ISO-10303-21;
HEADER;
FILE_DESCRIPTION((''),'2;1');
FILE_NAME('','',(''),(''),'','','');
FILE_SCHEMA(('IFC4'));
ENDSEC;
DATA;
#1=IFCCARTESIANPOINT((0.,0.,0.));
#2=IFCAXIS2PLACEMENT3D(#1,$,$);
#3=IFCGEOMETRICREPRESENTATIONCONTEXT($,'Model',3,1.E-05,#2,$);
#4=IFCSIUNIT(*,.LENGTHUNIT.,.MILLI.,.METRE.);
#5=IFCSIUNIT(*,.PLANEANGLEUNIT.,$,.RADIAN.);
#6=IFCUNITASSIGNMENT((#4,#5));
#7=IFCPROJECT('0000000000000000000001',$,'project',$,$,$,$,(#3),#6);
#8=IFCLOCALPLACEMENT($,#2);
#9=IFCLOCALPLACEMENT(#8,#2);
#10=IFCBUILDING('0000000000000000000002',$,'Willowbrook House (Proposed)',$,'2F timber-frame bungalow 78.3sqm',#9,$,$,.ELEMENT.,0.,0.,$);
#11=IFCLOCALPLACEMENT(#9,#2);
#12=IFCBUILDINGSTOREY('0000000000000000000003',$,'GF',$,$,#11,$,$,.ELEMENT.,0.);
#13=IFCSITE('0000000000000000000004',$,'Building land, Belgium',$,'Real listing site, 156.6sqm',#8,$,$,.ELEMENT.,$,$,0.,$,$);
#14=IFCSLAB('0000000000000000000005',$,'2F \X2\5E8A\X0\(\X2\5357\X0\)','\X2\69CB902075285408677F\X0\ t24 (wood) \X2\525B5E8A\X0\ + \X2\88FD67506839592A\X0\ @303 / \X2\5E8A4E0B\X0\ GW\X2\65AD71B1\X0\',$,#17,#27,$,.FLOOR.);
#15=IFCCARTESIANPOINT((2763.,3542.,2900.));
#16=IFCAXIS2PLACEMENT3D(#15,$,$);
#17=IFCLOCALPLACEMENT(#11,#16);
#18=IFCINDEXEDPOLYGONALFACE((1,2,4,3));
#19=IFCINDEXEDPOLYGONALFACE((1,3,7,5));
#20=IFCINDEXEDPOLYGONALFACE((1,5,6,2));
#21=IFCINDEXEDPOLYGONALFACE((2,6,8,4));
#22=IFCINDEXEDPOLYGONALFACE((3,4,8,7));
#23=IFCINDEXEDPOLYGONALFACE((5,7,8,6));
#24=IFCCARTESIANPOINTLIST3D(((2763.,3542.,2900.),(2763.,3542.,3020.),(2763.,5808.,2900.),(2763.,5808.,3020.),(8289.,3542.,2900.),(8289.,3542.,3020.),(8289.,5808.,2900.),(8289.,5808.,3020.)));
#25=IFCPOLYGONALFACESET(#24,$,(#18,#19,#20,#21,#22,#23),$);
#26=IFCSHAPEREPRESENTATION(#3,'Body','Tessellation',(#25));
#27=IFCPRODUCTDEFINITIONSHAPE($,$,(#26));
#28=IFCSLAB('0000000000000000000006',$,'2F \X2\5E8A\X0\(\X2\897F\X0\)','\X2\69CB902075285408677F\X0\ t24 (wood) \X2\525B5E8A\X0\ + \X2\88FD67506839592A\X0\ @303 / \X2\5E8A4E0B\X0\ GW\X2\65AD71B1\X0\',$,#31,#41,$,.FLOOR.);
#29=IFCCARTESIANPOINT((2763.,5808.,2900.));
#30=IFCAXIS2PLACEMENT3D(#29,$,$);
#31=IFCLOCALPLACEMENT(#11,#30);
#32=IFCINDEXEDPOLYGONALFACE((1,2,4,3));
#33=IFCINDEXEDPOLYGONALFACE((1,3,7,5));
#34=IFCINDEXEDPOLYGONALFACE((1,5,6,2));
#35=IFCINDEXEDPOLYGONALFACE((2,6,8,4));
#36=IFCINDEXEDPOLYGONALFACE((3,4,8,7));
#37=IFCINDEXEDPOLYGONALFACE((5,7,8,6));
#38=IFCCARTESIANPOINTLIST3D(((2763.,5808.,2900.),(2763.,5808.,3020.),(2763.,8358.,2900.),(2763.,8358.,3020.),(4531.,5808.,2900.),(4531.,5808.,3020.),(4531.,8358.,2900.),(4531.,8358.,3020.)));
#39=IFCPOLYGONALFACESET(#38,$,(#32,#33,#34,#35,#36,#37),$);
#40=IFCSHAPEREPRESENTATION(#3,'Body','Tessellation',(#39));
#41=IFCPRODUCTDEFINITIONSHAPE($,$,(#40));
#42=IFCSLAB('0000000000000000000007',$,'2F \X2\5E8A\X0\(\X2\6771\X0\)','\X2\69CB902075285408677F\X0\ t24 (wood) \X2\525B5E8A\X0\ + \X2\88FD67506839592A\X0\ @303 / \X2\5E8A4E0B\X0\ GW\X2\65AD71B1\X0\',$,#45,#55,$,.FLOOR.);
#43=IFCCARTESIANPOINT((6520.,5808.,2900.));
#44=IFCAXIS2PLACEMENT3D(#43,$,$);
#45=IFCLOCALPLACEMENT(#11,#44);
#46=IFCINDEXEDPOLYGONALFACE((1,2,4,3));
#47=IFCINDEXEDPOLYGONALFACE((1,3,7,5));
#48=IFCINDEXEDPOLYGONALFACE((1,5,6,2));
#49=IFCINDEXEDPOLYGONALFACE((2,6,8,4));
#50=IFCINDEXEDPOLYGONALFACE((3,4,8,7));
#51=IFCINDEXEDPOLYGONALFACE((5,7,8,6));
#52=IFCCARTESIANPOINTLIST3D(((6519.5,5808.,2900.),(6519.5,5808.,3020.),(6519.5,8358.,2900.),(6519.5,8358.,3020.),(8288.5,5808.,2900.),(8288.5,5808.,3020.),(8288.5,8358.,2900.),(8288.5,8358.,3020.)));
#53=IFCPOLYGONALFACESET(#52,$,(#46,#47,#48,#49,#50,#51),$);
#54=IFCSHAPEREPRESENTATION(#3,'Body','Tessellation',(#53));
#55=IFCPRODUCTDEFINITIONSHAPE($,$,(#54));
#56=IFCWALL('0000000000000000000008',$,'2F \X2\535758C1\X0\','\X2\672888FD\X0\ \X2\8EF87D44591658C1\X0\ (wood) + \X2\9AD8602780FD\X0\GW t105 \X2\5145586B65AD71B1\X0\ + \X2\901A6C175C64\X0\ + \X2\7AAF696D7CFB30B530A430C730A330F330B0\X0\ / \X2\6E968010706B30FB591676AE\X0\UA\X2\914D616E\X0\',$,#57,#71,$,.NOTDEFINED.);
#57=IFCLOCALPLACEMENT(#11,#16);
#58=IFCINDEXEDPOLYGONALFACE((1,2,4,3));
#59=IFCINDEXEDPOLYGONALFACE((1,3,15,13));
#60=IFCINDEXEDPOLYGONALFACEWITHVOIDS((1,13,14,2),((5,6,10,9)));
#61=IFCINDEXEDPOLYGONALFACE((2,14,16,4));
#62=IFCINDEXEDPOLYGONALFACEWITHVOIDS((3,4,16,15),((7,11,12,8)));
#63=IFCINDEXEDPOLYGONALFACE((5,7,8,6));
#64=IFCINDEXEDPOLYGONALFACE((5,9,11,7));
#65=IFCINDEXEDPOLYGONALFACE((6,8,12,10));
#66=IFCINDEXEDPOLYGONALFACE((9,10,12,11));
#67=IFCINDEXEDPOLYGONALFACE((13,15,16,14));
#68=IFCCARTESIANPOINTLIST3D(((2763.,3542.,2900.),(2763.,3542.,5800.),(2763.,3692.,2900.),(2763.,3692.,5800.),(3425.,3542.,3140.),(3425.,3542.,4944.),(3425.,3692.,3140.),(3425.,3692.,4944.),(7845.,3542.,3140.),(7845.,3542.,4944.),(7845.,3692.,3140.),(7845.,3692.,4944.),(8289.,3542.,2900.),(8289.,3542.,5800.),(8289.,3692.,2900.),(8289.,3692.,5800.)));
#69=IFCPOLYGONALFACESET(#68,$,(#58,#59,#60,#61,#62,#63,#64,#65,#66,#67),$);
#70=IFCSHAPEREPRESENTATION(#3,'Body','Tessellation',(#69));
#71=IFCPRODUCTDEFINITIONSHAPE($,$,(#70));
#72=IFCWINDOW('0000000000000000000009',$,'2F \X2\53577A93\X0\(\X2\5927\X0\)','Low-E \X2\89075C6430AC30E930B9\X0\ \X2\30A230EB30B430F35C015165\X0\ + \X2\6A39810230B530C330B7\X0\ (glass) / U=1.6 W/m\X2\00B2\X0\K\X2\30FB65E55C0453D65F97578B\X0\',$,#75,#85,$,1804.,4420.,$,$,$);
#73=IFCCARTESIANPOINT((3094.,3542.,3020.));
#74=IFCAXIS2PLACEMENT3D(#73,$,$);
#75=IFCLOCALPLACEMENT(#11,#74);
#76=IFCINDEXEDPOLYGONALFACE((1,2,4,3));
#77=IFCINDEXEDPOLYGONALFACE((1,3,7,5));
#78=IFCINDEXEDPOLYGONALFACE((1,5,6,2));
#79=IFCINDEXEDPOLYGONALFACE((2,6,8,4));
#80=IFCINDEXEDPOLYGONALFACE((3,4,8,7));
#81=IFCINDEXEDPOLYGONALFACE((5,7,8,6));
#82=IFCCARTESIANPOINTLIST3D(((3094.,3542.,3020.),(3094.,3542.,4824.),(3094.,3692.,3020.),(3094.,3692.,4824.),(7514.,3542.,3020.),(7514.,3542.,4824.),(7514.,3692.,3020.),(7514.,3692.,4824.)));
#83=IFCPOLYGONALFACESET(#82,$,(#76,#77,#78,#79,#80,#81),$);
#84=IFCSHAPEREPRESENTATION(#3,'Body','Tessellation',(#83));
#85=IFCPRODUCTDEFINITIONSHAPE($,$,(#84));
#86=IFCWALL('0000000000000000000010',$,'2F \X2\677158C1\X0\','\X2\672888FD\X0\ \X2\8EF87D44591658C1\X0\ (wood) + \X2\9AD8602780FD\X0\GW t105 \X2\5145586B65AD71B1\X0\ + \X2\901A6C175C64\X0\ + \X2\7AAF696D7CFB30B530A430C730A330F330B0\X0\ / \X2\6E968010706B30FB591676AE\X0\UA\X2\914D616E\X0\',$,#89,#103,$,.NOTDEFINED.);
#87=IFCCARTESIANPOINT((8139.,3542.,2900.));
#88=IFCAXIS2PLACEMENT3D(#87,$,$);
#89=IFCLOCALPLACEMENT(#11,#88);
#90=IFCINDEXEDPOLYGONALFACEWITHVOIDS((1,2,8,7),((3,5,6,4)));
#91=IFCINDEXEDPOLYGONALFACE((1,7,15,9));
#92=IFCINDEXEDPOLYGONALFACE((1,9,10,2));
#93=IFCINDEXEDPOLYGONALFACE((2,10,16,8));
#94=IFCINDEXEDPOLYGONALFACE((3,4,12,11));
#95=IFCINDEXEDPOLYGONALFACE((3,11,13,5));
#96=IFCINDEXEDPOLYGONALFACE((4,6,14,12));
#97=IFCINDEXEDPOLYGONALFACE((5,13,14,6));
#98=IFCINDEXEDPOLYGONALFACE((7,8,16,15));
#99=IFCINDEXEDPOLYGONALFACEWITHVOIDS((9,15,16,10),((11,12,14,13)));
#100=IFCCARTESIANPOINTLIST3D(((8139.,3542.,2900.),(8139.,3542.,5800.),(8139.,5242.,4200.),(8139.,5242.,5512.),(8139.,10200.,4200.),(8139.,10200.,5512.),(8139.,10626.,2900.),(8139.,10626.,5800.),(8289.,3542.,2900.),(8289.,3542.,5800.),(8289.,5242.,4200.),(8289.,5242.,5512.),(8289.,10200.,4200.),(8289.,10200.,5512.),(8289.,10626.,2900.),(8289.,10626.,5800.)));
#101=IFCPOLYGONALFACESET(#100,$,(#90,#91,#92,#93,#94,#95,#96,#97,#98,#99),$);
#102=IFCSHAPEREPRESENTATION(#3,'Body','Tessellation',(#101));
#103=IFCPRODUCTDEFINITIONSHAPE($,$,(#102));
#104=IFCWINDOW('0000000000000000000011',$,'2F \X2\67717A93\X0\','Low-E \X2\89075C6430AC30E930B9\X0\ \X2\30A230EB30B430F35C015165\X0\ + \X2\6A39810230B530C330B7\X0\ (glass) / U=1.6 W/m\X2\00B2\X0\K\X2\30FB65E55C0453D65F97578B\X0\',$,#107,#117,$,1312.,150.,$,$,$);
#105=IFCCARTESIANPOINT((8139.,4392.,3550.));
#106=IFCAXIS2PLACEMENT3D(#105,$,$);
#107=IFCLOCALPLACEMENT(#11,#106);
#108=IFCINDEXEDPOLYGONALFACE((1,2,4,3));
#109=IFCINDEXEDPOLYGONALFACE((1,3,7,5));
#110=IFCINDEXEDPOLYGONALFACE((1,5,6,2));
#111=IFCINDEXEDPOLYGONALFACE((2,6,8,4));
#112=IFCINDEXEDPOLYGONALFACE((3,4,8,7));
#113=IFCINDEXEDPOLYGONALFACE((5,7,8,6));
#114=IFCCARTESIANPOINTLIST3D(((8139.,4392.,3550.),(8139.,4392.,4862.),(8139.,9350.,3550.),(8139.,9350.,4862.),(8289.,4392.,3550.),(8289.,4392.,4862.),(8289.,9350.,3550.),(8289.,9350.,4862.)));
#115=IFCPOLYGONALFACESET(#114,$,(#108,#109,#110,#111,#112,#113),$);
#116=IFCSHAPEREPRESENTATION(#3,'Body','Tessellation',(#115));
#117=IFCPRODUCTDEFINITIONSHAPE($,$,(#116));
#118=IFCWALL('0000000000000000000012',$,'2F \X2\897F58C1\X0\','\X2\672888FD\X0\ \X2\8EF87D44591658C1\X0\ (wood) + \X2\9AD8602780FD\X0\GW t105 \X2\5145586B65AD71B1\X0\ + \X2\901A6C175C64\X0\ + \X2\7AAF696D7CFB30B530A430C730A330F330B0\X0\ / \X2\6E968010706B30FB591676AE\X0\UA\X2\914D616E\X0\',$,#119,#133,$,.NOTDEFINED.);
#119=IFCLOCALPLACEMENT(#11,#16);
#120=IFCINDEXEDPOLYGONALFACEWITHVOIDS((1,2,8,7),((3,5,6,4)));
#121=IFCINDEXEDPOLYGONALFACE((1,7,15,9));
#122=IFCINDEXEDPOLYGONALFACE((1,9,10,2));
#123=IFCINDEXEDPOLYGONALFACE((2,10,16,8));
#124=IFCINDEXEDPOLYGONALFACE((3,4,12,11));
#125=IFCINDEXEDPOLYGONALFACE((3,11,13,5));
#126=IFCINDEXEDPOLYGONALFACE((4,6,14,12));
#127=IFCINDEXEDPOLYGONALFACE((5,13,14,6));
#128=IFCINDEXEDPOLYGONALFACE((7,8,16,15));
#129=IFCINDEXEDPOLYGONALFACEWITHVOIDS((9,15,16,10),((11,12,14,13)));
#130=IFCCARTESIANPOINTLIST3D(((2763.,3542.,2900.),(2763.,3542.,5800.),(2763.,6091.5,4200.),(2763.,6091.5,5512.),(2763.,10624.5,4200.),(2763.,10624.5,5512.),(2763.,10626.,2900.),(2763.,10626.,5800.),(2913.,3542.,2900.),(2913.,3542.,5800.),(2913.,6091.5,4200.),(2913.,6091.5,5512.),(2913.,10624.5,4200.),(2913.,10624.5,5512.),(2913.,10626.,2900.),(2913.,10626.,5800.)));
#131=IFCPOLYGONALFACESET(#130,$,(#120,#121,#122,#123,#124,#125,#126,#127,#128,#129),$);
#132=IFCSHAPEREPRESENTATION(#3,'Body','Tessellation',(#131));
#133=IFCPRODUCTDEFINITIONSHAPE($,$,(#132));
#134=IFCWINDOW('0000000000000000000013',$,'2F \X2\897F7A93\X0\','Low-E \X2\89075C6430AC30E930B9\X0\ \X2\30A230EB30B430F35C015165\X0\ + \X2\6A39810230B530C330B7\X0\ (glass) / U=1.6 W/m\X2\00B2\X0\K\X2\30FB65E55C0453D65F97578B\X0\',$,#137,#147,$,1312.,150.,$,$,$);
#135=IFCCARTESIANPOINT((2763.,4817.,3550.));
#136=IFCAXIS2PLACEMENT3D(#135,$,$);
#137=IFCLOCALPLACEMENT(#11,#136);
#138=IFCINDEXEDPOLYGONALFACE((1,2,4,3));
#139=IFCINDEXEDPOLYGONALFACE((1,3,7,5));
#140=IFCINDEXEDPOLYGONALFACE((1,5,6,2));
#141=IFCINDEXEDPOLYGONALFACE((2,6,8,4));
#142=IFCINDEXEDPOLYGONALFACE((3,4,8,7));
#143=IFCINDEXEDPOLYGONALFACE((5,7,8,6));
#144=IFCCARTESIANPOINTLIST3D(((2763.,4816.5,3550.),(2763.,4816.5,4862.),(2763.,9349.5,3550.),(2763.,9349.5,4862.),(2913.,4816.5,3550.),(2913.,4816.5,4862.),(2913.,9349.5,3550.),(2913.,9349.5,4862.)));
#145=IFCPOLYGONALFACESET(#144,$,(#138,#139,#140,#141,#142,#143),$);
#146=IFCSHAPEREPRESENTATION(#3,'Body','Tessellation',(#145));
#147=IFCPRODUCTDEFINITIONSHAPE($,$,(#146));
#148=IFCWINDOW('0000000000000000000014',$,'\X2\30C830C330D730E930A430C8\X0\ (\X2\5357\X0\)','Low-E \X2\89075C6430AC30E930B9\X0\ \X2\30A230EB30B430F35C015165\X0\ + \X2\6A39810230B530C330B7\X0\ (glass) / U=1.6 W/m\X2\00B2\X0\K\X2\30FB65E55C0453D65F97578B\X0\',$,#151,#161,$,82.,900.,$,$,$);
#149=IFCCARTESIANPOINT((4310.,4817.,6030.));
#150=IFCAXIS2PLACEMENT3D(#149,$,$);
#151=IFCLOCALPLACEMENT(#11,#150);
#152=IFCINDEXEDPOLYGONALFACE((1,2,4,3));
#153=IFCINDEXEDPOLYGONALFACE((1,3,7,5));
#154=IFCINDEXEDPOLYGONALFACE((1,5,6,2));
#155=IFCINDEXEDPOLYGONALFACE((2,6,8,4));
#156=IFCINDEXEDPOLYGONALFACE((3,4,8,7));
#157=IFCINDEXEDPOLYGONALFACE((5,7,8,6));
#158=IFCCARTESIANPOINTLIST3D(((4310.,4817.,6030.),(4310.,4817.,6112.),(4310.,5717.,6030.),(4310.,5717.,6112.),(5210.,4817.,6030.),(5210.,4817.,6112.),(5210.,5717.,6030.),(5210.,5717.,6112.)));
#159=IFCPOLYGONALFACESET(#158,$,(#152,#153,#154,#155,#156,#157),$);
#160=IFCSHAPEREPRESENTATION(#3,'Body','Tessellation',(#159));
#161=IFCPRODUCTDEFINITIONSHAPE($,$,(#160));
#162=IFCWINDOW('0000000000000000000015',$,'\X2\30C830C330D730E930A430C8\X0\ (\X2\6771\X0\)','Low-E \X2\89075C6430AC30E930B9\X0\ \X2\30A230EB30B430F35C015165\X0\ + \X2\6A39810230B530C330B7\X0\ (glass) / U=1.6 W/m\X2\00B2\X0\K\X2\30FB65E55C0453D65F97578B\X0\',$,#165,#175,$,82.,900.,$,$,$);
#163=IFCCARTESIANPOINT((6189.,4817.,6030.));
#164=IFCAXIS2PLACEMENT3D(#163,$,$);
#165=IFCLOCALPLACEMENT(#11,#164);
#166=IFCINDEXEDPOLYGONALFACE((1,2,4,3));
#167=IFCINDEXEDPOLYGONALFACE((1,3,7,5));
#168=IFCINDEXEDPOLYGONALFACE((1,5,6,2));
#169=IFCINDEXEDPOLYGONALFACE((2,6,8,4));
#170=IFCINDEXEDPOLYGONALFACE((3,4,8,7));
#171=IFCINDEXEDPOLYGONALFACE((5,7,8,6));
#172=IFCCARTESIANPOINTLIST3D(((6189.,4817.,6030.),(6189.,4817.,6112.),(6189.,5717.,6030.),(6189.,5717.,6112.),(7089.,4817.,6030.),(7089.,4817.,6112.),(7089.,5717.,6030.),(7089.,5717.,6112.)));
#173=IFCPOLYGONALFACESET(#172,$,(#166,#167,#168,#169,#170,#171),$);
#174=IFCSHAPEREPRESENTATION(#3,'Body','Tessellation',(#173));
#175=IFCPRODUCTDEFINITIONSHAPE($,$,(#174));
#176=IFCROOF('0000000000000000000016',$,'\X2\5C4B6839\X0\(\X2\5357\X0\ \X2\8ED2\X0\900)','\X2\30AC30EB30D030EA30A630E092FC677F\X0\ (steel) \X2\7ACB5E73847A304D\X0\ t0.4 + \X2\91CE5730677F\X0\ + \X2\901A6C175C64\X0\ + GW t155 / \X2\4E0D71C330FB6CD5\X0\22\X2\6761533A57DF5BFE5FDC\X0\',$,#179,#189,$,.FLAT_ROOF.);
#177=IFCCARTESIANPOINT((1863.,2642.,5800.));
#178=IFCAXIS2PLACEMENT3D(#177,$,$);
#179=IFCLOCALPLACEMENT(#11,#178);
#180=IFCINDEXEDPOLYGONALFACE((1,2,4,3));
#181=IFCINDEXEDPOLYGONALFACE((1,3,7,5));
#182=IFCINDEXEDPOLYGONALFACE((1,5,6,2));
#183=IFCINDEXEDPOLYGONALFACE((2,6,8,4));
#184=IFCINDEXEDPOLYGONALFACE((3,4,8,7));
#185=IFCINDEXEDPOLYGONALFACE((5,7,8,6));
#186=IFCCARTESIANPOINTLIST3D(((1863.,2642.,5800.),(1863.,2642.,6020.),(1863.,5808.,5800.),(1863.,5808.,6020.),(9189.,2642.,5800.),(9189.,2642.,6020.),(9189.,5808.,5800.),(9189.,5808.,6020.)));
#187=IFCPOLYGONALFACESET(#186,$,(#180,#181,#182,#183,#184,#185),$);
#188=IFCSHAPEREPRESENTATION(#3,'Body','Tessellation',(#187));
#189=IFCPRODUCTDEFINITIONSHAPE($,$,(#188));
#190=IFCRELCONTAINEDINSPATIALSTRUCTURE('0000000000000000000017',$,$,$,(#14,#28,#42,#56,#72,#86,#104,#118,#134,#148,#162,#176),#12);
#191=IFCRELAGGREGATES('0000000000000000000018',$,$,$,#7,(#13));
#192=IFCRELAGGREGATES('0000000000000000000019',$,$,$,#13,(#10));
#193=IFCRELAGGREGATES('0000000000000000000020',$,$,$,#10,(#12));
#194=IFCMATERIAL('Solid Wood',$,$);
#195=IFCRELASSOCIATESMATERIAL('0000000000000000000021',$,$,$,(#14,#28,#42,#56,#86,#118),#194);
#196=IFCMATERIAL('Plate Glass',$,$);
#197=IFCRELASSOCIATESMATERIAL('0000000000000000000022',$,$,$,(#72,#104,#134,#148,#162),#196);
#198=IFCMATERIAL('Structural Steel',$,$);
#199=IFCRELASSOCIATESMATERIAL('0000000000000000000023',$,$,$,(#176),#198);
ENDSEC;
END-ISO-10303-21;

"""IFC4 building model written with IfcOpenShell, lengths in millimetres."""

from ifc_helpers import new_model, si_unit, frame, frame_2d, origin, place, context, project, spatial, rectangle, extrude, material, element, fill, save


model = new_model("IFC4")

# Units and contexts
model_context = context("Model", 3, precision=1e-05, world=origin())
ifc_project = project(units=[si_unit("LENGTHUNIT", "METRE", prefix="MILLI"), si_unit("PLANEANGLEUNIT", "RADIAN")], contexts=[model_context])

# Site, building, storey
site_placement = place(None, origin())
site = spatial("IfcSite", under=ifc_project, at=site_placement, Name="Building land, Belgium", ObjectType="Real listing site, 156.6sqm", CompositionType="ELEMENT", RefElevation=0.0)
building_placement = place(site_placement, origin())
building = spatial("IfcBuilding", under=site, at=building_placement, Name="Willowbrook House (Proposed)", ObjectType="2F timber-frame bungalow 78.3sqm", CompositionType="ELEMENT", ElevationOfRefHeight=0.0, ElevationOfTerrain=0.0)
storey_placement = place(building_placement, origin())
storey = spatial("IfcBuildingStorey", under=building, at=storey_placement, Name="GF", CompositionType="ELEMENT", Elevation=0.0)

# Slabs
ifc_material_1 = material(Name="Solid Wood")
slab_1_placement = place(storey_placement, frame((2763.0, 3542.0, 2900.0)))
element("IfcSlab", 1, at=slab_1_placement, inside=storey, material=ifc_material_1, Name="2F 床(南)", Description="構造用合板 t24 (wood) 剛床 + 製材根太 @303 / 床下 GW断熱", PredefinedType="FLOOR", context=model_context, shape_type="SweptSolid", body=[
    extrude(rectangle(XDim=5526.0, YDim=2266.0, at=frame_2d((2763.0, 1133.0))), frame((2763.0, 3542.0, 2900.0)), (0.0, 0.0, 1.0), 120.0),
])
slab_2_placement = place(storey_placement, frame((2763.0, 5808.0, 2900.0)))
element("IfcSlab", 2, at=slab_2_placement, inside=storey, material=ifc_material_1, Name="2F 床(西)", Description="構造用合板 t24 (wood) 剛床 + 製材根太 @303 / 床下 GW断熱", PredefinedType="FLOOR", context=model_context, shape_type="SweptSolid", body=[
    extrude(rectangle(XDim=1768.0, YDim=2550.0, at=frame_2d((884.0, 1275.0))), frame((2763.0, 5808.0, 2900.0)), (0.0, 0.0, 1.0), 120.0),
])
slab_3_placement = place(storey_placement, frame((6520.0, 5808.0, 2900.0)))
element("IfcSlab", 3, at=slab_3_placement, inside=storey, material=ifc_material_1, Name="2F 床(東)", Description="構造用合板 t24 (wood) 剛床 + 製材根太 @303 / 床下 GW断熱", PredefinedType="FLOOR", context=model_context, shape_type="SweptSolid", body=[
    extrude(rectangle(XDim=1769.0, YDim=2550.0, at=frame_2d((884.0, 1275.0))), frame((6520.0, 5808.0, 2900.0)), (0.0, 0.0, 1.0), 120.0),
])

# Walls, openings, windows
wall_1_placement = place(storey_placement, frame((2763.0, 3542.0, 2900.0)))
wall_1 = element("IfcWall", 4, at=wall_1_placement, inside=storey, material=ifc_material_1, Name="2F 南壁", Description="木製 軸組外壁 (wood) + 高性能GW t105 充填断熱 + 通気層 + 窯業系サイディング / 準耐火・外皮UA配慮", PredefinedType="NOTDEFINED", context=model_context, shape_type="SweptSolid", body=[
    extrude(rectangle(XDim=5526.0, YDim=150.0, at=frame_2d((2763.0, 75.0))), frame((2763.0, 3542.0, 2900.0)), (0.0, 0.0, 1.0), 2900.0),
])
opening_1_placement = place(storey_placement, frame((3094.0, 3542.0, 3020.0)))
opening_1 = element("IfcOpeningElement", 5, at=opening_1_placement, cuts=wall_1, PredefinedType="NOTDEFINED", context=model_context, shape_type="SweptSolid", body=[
    extrude(rectangle(XDim=4420.0, YDim=150.0, at=frame_2d((2210.0, 75.0))), frame((3094.0, 3542.0, 3020.0)), (0.0, 0.0, 1.0), 1804.0),
])
ifc_material_2 = material(Name="Plate Glass")
window_1_placement = place(storey_placement, frame((3094.0, 3542.0, 3020.0)))
window_1 = element("IfcWindow", 6, at=window_1_placement, inside=storey, material=ifc_material_2, Name="2F 南窓(大)", Description="Low-E 複層ガラス アルゴン封入 + 樹脂サッシ (glass) / U=1.6 W/m²K・日射取得型", OverallHeight=1804.0, OverallWidth=4420.0, context=model_context, shape_type="SweptSolid", body=[
    extrude(rectangle(XDim=4420.0, YDim=150.0, at=frame_2d((2210.0, 75.0))), frame((3094.0, 3542.0, 3020.0)), (0.0, 0.0, 1.0), 1804.0),
])
fill(opening_1, window_1)
wall_2_placement = place(storey_placement, frame((8139.0, 3542.0, 2900.0)))
wall_2 = element("IfcWall", 7, at=wall_2_placement, inside=storey, material=ifc_material_1, Name="2F 東壁", Description="木製 軸組外壁 (wood) + 高性能GW t105 充填断熱 + 通気層 + 窯業系サイディング / 準耐火・外皮UA配慮", PredefinedType="NOTDEFINED", context=model_context, shape_type="SweptSolid", body=[
    extrude(rectangle(XDim=150.0, YDim=7084.0, at=frame_2d((75.0, 3542.0))), frame((8139.0, 3542.0, 2900.0)), (0.0, 0.0, 1.0), 2900.0),
])
opening_2_placement = place(storey_placement, frame((8139.0, 4392.0, 3550.0)))
opening_2 = element("IfcOpeningElement", 8, at=opening_2_placement, cuts=wall_2, PredefinedType="NOTDEFINED", context=model_context, shape_type="SweptSolid", body=[
    extrude(rectangle(XDim=150.0, YDim=4958.0, at=frame_2d((75.0, 2479.0))), frame((8139.0, 4392.0, 3550.0)), (0.0, 0.0, 1.0), 1312.0),
])
window_2_placement = place(storey_placement, frame((8139.0, 4392.0, 3550.0)))
window_2 = element("IfcWindow", 9, at=window_2_placement, inside=storey, material=ifc_material_2, Name="2F 東窓", Description="Low-E 複層ガラス アルゴン封入 + 樹脂サッシ (glass) / U=1.6 W/m²K・日射取得型", OverallHeight=1312.0, OverallWidth=150.0, context=model_context, shape_type="SweptSolid", body=[
    extrude(rectangle(XDim=150.0, YDim=4958.0, at=frame_2d((75.0, 2479.0))), frame((8139.0, 4392.0, 3550.0)), (0.0, 0.0, 1.0), 1312.0),
])
fill(opening_2, window_2)
wall_3_placement = place(storey_placement, frame((2763.0, 3542.0, 2900.0)))
wall_3 = element("IfcWall", 10, at=wall_3_placement, inside=storey, material=ifc_material_1, Name="2F 西壁", Description="木製 軸組外壁 (wood) + 高性能GW t105 充填断熱 + 通気層 + 窯業系サイディング / 準耐火・外皮UA配慮", PredefinedType="NOTDEFINED", context=model_context, shape_type="SweptSolid", body=[
    extrude(rectangle(XDim=150.0, YDim=7084.0, at=frame_2d((75.0, 3542.0))), frame((2763.0, 3542.0, 2900.0)), (0.0, 0.0, 1.0), 2900.0),
])
opening_3_placement = place(storey_placement, frame((2763.0, 4817.0, 3550.0)))
opening_3 = element("IfcOpeningElement", 11, at=opening_3_placement, cuts=wall_3, PredefinedType="NOTDEFINED", context=model_context, shape_type="SweptSolid", body=[
    extrude(rectangle(XDim=150.0, YDim=4533.0, at=frame_2d((75.0, 2266.0))), frame((2763.0, 4817.0, 3550.0)), (0.0, 0.0, 1.0), 1312.0),
])
window_3_placement = place(storey_placement, frame((2763.0, 4817.0, 3550.0)))
window_3 = element("IfcWindow", 12, at=window_3_placement, inside=storey, material=ifc_material_2, Name="2F 西窓", Description="Low-E 複層ガラス アルゴン封入 + 樹脂サッシ (glass) / U=1.6 W/m²K・日射取得型", OverallHeight=1312.0, OverallWidth=150.0, context=model_context, shape_type="SweptSolid", body=[
    extrude(rectangle(XDim=150.0, YDim=4533.0, at=frame_2d((75.0, 2266.0))), frame((2763.0, 4817.0, 3550.0)), (0.0, 0.0, 1.0), 1312.0),
])
fill(opening_3, window_3)

# Windows
window_4_placement = place(storey_placement, frame((4310.0, 4817.0, 6030.0)))
element("IfcWindow", 13, at=window_4_placement, inside=storey, material=ifc_material_2, Name="トップライト (南)", Description="Low-E 複層ガラス アルゴン封入 + 樹脂サッシ (glass) / U=1.6 W/m²K・日射取得型", OverallHeight=82.0, OverallWidth=900.0, context=model_context, shape_type="SweptSolid", body=[
    extrude(rectangle(XDim=900.0, YDim=900.0, at=frame_2d((450.0, 450.0))), frame((4310.0, 4817.0, 6030.0)), (0.0, 0.0, 1.0), 82.0),
])
window_5_placement = place(storey_placement, frame((6189.0, 4817.0, 6030.0)))
element("IfcWindow", 14, at=window_5_placement, inside=storey, material=ifc_material_2, Name="トップライト (東)", Description="Low-E 複層ガラス アルゴン封入 + 樹脂サッシ (glass) / U=1.6 W/m²K・日射取得型", OverallHeight=82.0, OverallWidth=900.0, context=model_context, shape_type="SweptSolid", body=[
    extrude(rectangle(XDim=900.0, YDim=900.0, at=frame_2d((450.0, 450.0))), frame((6189.0, 4817.0, 6030.0)), (0.0, 0.0, 1.0), 82.0),
])

# Roof
ifc_material_3 = material(Name="Structural Steel")
roof_1_placement = place(storey_placement, frame((1863.0, 2642.0, 5800.0)))
element("IfcRoof", 15, at=roof_1_placement, inside=storey, material=ifc_material_3, Name="屋根(南 軒900)", Description="ガルバリウム鋼板 (steel) 立平葺き t0.4 + 野地板 + 通気層 + GW t155 / 不燃・法22条区域対応", PredefinedType="FLAT_ROOF", context=model_context, shape_type="SweptSolid", body=[
    extrude(rectangle(XDim=7326.0, YDim=3166.0, at=frame_2d((3663.0, 1583.0))), frame((1863.0, 2642.0, 5800.0)), (0.0, 0.0, 1.0), 220.0),
])

save(model, "model.ifc")
